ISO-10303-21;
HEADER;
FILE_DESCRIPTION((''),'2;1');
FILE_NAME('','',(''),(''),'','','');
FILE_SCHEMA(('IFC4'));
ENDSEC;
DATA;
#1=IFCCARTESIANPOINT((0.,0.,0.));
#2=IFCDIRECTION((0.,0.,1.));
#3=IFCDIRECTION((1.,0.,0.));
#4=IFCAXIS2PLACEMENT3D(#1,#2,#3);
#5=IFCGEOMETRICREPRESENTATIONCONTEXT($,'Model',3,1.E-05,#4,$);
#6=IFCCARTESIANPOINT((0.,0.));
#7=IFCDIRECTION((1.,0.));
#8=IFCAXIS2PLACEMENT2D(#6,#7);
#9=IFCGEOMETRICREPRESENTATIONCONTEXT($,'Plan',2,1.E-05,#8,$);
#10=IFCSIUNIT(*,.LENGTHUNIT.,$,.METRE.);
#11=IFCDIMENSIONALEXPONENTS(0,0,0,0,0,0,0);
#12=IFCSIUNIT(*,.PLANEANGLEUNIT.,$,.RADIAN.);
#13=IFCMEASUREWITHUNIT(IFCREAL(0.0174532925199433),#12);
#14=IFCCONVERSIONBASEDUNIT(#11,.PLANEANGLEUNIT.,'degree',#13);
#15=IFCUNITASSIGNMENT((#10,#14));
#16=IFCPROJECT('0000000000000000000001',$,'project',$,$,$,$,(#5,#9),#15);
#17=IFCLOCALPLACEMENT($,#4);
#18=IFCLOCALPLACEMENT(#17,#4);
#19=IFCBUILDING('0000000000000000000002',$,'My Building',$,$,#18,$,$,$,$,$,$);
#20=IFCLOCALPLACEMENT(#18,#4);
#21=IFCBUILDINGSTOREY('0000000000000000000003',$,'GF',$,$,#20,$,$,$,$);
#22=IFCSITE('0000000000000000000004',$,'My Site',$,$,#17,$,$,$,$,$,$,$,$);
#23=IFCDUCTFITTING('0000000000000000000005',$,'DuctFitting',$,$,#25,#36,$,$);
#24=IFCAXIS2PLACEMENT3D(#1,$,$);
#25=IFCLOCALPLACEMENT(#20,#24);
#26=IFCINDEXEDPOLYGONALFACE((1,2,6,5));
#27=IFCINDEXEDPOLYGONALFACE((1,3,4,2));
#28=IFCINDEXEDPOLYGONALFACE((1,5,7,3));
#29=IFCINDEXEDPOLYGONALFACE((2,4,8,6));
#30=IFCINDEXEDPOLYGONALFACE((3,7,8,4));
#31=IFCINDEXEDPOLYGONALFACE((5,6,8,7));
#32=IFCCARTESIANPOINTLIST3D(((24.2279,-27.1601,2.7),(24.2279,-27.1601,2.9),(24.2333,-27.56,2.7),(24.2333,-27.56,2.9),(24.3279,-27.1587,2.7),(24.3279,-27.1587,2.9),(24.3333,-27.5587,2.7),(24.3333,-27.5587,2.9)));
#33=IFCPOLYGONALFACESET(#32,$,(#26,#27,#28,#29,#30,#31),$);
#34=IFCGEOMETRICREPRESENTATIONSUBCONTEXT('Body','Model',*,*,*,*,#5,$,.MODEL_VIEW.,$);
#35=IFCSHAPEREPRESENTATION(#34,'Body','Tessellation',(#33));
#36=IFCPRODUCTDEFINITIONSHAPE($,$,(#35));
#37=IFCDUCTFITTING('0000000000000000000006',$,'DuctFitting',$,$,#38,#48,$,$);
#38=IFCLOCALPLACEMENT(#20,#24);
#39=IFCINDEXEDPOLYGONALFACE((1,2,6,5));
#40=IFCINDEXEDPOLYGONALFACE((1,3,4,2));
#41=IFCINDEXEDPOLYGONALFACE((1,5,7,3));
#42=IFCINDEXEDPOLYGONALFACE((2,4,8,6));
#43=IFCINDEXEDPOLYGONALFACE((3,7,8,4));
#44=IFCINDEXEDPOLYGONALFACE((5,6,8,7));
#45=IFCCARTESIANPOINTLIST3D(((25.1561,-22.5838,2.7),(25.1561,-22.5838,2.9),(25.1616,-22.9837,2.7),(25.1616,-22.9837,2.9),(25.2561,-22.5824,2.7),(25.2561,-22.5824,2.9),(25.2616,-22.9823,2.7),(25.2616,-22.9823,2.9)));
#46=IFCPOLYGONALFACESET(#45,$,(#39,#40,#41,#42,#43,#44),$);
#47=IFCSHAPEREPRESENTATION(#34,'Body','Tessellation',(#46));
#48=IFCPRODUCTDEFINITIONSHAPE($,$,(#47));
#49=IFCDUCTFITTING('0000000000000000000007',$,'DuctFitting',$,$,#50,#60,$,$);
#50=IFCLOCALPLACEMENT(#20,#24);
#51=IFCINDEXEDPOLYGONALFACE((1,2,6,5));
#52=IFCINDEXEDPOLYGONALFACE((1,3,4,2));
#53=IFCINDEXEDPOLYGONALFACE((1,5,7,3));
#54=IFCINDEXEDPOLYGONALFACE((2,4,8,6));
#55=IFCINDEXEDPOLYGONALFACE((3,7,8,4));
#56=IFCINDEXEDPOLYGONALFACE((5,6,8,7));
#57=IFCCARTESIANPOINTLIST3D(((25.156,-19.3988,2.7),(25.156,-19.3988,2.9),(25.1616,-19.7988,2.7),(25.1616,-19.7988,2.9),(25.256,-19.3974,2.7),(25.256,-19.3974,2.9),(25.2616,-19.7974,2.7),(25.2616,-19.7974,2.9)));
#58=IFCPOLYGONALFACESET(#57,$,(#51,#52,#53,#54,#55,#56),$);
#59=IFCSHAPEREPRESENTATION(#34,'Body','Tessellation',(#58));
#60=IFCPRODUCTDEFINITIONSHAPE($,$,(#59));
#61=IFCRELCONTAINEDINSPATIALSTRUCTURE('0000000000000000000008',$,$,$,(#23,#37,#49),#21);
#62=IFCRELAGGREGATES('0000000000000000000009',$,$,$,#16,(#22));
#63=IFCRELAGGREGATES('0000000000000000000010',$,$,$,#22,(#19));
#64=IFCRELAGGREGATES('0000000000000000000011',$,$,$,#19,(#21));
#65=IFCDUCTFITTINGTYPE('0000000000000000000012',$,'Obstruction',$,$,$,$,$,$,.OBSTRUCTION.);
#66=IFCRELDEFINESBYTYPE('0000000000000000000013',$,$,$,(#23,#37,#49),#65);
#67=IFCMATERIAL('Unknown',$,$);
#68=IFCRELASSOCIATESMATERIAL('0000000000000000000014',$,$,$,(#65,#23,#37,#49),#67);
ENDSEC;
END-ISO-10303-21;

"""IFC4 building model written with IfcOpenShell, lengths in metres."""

from ifc_helpers import new_model, entity, si_unit, converted_unit, frame, origin_with_axes, origin_2d_with_axis, place, context, subcontext, project, spatial, rectangle, extrude, material, material_profile, profile_set, profile_usage, type_object, element, save


model = new_model("IFC4")

# Units and contexts
model_context = context("Model", 3, precision=1e-05, world=origin_with_axes())
plan_context = context("Plan", 2, precision=1e-05, world=origin_2d_with_axis())
body_context_1 = subcontext(model_context, "Body", "Model", "MODEL_VIEW")
ifc_project = project(units=[si_unit("LENGTHUNIT", "METRE"), converted_unit("PLANEANGLEUNIT", "degree", entity("IfcReal", 0.0174532925199433), si_unit("PLANEANGLEUNIT", "RADIAN"), dimensions=[0, 0, 0, 0, 0, 0, 0])], contexts=[model_context, plan_context])

# Site, building, storey
site_placement = place(None, origin_with_axes())
site = spatial("IfcSite", under=ifc_project, at=site_placement, Name="My Site")
building_placement = place(site_placement, origin_with_axes())
building = spatial("IfcBuilding", under=site, at=building_placement, Name="My Building")
storey_placement = place(building_placement, origin_with_axes())
storey = spatial("IfcBuildingStorey", under=building, at=storey_placement, Name="GF")

# Shared definitions
ifc_material = material(Name="Unknown")

# Duct fittings
ifc_material_profile_1 = material_profile(ifc_material, rectangle(XDim=0.4, YDim=0.2))
ifc_profile_set_1 = profile_set([ifc_material_profile_1])
duct_fitting_type_1 = type_object("IfcDuctFittingType", Name="Obstruction", PredefinedType="OBSTRUCTION", material=ifc_profile_set_1)
ifc_profile_usage_1 = profile_usage(ifc_profile_set_1, cardinal=5)
duct_fitting_1_placement = place(storey_placement, frame((24.2306, -27.3601, 2.8), z_axis=(0.999906, 0.013713, 0.0), x_axis=(-0.013713, 0.999906, 0.0)))
element("IfcDuctFitting", 1, at=duct_fitting_1_placement, inside=storey, type_object=duct_fitting_type_1, material=ifc_profile_usage_1, Name="DuctFitting", context=body_context_1, shape_type="SweptSolid", body=[
    extrude(rectangle(XDim=0.4, YDim=0.2), origin_with_axes(), (0.0, 0.0, 1.0), 0.1),
])
ifc_profile_usage_2 = profile_usage(ifc_profile_set_1, cardinal=5)
duct_fitting_2_placement = place(storey_placement, frame((25.1588, -22.7837, 2.8), z_axis=(0.999906, 0.013713, 0.0), x_axis=(-0.013713, 0.999906, 0.0)))
element("IfcDuctFitting", 2, at=duct_fitting_2_placement, inside=storey, type_object=duct_fitting_type_1, material=ifc_profile_usage_2, Name="DuctFitting", context=body_context_1, shape_type="SweptSolid", body=[
    extrude(rectangle(XDim=0.4, YDim=0.2), origin_with_axes(), (0.0, 0.0, 1.0), 0.1),
])
ifc_profile_usage_3 = profile_usage(ifc_profile_set_1, cardinal=5)
duct_fitting_3_placement = place(storey_placement, frame((25.1588, -19.5988, 2.8), z_axis=(0.9999, 0.01412, 0.0), x_axis=(-0.01412, 0.9999, 0.0)))
element("IfcDuctFitting", 3, at=duct_fitting_3_placement, inside=storey, type_object=duct_fitting_type_1, material=ifc_profile_usage_3, Name="DuctFitting", context=body_context_1, shape_type="SweptSolid", body=[
    extrude(rectangle(XDim=0.4, YDim=0.2), origin_with_axes(), (0.0, 0.0, 1.0), 0.1),
])

save(model, "model.ifc")
